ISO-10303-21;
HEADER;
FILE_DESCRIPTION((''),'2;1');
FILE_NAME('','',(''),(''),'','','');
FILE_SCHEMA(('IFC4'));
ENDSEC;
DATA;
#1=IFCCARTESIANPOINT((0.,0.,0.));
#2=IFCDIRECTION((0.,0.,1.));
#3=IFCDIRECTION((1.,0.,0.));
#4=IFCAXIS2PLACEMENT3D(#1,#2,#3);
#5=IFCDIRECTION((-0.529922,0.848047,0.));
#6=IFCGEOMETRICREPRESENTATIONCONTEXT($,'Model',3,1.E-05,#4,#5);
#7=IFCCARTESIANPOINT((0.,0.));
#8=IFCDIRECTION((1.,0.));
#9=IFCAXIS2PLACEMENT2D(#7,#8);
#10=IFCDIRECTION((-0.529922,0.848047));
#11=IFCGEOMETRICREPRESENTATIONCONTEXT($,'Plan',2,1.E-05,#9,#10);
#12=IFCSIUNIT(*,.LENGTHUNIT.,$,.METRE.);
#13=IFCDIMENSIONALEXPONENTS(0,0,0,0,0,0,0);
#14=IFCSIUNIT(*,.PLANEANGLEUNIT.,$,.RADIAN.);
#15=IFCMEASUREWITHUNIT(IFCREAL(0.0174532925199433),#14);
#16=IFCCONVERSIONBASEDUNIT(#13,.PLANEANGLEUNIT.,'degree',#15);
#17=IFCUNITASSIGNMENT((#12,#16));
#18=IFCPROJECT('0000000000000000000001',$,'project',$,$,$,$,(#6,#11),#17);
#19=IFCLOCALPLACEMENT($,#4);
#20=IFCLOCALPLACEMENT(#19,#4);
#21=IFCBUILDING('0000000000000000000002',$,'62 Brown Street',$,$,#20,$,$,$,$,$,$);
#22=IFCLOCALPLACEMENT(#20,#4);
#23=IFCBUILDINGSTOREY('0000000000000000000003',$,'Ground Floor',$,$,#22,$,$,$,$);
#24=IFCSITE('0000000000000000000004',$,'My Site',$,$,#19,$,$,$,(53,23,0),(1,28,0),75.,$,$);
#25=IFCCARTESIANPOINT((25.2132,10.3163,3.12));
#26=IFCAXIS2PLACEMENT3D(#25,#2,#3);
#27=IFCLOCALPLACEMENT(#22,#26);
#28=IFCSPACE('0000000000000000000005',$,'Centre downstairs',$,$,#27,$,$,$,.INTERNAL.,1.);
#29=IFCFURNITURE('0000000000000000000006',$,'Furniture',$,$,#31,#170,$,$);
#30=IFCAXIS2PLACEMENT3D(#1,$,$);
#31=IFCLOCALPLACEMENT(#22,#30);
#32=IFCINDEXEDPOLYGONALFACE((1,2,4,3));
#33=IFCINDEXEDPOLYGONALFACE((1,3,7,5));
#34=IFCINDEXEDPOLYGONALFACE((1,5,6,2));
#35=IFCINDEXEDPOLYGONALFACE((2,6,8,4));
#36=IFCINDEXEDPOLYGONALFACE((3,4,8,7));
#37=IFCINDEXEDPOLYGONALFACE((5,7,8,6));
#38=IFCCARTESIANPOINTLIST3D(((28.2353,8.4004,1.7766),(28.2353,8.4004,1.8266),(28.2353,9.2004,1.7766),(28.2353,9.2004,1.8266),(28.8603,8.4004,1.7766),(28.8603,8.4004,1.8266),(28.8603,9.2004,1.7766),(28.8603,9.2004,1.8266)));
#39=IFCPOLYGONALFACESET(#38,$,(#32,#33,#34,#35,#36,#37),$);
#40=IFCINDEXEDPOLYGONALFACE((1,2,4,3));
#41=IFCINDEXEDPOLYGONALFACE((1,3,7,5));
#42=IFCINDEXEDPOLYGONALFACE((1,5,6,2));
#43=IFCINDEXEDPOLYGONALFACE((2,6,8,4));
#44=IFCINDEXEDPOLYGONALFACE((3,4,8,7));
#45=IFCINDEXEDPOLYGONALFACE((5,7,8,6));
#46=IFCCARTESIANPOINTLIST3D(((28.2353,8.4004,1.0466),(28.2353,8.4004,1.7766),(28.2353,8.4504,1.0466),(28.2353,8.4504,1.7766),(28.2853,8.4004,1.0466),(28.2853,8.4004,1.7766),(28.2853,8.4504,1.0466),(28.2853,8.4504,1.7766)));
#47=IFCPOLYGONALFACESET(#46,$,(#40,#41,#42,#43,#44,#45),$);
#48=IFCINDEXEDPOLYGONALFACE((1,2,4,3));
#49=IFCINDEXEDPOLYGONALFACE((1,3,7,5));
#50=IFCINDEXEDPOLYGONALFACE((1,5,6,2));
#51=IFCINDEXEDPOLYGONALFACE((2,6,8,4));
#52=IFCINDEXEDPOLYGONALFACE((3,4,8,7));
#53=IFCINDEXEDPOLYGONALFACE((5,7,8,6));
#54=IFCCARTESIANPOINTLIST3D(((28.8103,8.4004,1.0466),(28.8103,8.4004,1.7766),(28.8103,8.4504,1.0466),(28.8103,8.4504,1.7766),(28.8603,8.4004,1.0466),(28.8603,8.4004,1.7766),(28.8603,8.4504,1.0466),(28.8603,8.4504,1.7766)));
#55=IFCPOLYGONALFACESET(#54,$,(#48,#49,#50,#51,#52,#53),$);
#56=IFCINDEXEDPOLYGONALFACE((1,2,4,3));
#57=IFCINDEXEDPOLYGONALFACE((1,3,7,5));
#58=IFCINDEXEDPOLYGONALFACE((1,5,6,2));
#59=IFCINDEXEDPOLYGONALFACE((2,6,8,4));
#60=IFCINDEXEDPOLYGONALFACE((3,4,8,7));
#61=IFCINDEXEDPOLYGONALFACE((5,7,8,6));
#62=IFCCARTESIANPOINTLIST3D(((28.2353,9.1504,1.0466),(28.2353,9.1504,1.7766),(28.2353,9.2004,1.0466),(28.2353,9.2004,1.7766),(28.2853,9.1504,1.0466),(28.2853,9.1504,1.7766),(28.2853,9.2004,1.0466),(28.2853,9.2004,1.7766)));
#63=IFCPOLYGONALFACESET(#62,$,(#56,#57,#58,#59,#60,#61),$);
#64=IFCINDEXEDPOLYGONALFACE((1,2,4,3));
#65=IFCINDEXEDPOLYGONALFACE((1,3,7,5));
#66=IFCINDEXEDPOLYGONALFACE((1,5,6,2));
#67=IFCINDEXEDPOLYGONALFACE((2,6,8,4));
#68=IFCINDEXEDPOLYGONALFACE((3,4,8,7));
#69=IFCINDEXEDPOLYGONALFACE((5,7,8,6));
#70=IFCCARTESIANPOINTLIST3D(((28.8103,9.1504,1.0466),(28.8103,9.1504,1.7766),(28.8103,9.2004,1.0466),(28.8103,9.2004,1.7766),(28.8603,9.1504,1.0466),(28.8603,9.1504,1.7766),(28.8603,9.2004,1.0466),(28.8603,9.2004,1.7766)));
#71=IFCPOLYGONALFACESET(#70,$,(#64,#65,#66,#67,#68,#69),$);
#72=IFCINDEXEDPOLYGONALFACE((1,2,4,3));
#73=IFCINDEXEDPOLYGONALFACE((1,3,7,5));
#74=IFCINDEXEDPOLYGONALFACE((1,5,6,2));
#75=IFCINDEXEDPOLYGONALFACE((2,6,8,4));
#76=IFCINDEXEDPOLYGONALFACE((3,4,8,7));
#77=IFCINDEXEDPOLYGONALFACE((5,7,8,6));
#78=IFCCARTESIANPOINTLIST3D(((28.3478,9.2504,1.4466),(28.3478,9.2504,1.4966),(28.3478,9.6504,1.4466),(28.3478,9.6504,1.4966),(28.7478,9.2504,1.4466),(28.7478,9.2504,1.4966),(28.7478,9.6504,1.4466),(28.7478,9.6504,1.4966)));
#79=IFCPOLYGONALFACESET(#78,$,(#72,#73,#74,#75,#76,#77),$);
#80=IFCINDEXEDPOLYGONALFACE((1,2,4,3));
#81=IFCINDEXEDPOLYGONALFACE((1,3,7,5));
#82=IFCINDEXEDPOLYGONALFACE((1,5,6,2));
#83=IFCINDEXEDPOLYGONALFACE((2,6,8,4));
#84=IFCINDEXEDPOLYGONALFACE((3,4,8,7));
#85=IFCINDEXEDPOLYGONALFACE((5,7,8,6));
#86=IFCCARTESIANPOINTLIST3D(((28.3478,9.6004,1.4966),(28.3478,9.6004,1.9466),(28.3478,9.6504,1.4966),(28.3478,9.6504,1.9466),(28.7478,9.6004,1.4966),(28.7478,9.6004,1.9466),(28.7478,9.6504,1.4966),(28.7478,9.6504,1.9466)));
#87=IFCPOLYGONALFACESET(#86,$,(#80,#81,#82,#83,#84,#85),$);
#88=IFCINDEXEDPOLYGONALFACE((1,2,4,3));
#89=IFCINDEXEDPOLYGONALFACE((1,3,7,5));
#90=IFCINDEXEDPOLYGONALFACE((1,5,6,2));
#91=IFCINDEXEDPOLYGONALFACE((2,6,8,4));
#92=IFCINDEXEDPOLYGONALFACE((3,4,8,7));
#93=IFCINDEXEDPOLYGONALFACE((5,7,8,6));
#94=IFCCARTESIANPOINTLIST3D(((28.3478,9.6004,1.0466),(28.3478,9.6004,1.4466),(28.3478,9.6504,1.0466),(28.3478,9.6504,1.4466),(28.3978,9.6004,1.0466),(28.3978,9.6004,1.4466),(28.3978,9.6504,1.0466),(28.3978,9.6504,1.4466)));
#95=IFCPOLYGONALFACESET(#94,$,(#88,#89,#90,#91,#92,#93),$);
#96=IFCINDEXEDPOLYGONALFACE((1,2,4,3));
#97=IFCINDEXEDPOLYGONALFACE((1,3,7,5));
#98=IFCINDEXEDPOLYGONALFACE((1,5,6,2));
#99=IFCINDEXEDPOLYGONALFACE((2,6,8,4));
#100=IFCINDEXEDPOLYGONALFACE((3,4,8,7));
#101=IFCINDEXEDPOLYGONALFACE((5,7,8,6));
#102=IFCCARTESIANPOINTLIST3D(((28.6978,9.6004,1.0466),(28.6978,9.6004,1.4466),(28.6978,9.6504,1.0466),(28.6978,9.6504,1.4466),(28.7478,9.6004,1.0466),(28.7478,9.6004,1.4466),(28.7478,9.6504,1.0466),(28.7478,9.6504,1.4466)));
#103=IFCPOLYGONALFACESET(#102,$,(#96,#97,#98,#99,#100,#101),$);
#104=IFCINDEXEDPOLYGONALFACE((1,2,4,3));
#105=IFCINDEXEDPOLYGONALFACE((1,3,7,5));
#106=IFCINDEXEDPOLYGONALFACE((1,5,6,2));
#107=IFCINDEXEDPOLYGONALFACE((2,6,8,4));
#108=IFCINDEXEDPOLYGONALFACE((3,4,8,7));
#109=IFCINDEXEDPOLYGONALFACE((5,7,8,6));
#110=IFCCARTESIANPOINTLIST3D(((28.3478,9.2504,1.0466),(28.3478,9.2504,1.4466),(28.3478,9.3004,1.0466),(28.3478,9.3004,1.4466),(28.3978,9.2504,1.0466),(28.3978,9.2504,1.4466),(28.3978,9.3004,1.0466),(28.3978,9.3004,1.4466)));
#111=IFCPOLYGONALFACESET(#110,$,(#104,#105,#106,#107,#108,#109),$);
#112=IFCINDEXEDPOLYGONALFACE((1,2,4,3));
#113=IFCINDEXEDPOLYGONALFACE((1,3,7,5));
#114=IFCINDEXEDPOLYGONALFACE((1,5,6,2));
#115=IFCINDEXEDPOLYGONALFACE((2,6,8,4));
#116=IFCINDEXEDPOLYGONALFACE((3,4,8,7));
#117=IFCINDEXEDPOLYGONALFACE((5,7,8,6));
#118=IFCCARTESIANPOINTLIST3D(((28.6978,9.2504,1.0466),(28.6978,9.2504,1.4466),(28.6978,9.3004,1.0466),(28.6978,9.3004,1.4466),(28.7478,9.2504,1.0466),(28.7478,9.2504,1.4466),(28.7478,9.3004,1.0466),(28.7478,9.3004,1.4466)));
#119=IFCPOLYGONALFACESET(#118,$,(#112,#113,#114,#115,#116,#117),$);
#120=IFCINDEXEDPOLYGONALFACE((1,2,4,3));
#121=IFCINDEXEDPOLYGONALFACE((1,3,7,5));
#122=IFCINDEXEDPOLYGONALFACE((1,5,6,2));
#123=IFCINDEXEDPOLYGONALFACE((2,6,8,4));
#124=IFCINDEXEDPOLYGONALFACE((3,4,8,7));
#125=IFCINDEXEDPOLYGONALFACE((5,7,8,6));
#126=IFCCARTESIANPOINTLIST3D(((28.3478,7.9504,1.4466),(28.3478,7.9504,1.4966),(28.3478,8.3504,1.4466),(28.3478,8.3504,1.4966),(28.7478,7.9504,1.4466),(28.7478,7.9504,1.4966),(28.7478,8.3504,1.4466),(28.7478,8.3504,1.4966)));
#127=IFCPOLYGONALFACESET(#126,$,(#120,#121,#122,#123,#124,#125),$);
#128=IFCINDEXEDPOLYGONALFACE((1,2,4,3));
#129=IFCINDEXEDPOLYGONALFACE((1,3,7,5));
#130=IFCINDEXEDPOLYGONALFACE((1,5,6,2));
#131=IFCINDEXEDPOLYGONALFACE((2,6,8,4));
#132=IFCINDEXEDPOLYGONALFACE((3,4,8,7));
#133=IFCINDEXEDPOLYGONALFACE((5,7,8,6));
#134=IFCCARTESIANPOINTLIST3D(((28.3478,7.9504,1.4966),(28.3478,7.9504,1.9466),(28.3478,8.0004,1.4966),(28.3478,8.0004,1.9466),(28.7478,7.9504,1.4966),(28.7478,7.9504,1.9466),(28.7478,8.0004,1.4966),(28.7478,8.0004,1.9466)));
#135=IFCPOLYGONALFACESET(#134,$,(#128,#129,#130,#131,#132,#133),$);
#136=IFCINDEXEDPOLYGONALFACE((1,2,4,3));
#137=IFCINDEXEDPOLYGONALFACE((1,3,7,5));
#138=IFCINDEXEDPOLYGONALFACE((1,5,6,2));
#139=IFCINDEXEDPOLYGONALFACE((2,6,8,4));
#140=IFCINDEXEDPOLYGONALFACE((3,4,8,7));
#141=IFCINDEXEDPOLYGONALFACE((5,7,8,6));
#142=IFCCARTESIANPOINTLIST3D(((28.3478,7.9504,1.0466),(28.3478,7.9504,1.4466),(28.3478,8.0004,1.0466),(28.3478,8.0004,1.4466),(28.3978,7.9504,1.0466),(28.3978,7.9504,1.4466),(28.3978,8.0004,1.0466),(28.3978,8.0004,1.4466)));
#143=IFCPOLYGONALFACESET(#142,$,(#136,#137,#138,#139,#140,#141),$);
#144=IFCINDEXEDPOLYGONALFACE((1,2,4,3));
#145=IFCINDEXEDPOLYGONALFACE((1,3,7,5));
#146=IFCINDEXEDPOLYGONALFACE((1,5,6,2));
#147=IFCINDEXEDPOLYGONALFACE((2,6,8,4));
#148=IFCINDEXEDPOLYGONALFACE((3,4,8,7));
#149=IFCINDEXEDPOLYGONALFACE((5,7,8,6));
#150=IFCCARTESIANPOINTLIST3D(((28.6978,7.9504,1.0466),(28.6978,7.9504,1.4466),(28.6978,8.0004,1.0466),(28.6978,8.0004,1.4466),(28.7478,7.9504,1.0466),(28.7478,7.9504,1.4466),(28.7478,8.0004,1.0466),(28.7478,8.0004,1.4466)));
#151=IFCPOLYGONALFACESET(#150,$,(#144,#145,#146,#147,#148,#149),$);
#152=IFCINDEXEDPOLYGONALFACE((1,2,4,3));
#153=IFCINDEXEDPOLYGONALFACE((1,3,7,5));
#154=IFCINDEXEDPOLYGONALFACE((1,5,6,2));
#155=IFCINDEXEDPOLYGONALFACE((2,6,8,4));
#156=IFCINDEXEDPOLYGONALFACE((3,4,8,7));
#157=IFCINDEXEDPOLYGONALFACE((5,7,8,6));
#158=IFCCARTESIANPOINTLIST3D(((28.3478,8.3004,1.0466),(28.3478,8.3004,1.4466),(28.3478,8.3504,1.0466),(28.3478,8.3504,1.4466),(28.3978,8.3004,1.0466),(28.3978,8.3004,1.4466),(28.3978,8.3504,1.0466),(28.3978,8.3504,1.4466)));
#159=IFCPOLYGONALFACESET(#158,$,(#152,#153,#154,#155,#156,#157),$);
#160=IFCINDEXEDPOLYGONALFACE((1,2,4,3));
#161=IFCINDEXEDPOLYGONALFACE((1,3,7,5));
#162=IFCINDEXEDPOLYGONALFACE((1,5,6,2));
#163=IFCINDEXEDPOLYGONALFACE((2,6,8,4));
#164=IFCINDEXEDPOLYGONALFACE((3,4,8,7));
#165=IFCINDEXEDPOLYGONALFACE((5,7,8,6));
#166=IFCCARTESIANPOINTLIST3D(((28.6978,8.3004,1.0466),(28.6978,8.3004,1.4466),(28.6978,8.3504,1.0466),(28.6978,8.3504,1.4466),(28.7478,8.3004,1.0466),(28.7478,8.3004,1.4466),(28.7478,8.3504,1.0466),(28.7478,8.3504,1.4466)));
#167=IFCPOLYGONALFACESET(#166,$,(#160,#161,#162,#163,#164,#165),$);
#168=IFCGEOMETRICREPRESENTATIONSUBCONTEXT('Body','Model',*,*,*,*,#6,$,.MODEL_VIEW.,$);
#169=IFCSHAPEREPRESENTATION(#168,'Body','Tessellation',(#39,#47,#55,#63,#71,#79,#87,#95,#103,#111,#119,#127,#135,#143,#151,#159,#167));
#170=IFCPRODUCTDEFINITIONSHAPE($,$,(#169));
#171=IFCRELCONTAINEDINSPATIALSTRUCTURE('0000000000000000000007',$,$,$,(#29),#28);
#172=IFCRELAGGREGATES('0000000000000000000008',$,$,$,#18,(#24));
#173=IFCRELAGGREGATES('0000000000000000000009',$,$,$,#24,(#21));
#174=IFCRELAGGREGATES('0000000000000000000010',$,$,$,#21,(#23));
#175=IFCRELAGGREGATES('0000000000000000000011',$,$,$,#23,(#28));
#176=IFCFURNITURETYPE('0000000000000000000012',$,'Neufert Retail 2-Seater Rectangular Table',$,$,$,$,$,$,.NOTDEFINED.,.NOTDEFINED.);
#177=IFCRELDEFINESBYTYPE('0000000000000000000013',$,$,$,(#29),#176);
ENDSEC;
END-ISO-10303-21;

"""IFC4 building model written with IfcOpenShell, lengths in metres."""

from ifc_helpers import new_model, entity, si_unit, converted_unit, direction, frame, origin_with_axes, origin_2d_with_axis, place, context, subcontext, project, spatial, line, indexed_curve, outline, extrude, shape, source, transform, mapped, type_object, type_shapes, element, save


model = new_model("IFC4")

# Units and contexts
model_context = context("Model", 3, precision=1e-05, world=origin_with_axes(), true_north=direction((-0.529922, 0.848047, 0.0)))
plan_context = context("Plan", 2, precision=1e-05, world=origin_2d_with_axis(), true_north=direction((-0.529922, 0.848047)))
body_context_1 = subcontext(model_context, "Body", "Model", "MODEL_VIEW")
body_context_2 = subcontext(plan_context, "Body", "Plan", "PLAN_VIEW")
ifc_project = project(units=[si_unit("LENGTHUNIT", "METRE"), converted_unit("PLANEANGLEUNIT", "degree", entity("IfcReal", 0.0174532925199433), si_unit("PLANEANGLEUNIT", "RADIAN"), dimensions=[0, 0, 0, 0, 0, 0, 0])], contexts=[model_context, plan_context])

# Site, building, storey
site_placement = place(None, origin_with_axes())
site = spatial("IfcSite", under=ifc_project, at=site_placement, Name="My Site", RefLatitude=(53, 23, 0), RefLongitude=(1, 28, 0), RefElevation=75.0)
building_placement = place(site_placement, origin_with_axes())
building = spatial("IfcBuilding", under=site, at=building_placement, Name="62 Brown Street")
storey_placement = place(building_placement, origin_with_axes())
storey = spatial("IfcBuildingStorey", under=building, at=storey_placement, Name="Ground Floor")

# Shared definitions
space_placement = place(storey_placement, frame((25.2132, 10.3163, 3.12), z_axis=(0.0, 0.0, 1.0), x_axis=(1.0, 0.0, 0.0)))
space = spatial("IfcSpace", under=storey, at=space_placement, Name="Centre downstairs", PredefinedType="INTERNAL", ElevationWithFlooring=1.0)

# Furniture
furniture_type_1 = type_object("IfcFurnitureType", Name="Neufert Retail 2-Seater Rectangular Table", AssemblyPlace="NOTDEFINED", PredefinedType="NOTDEFINED")
shared_shape_1 = source(origin_with_axes(), body_context_1, "Body", "SweptSolid", [
    extrude(outline(indexed_curve([(0.0, 0.0), (0.625, 0.0), (0.625, 0.8), (0.0, 0.8)], segments=[line(1, 2, 3, 4, 1)])), frame((-0.3125, -0.4, 0.73), z_axis=(0.0, 0.0, 1.0), x_axis=(1.0, 0.0, 0.0)), (0.0, 0.0, 1.0), 0.05),
    extrude(outline(indexed_curve([(0.0, 0.0), (0.05, 0.0), (0.05, 0.05), (0.0, 0.05)], segments=[line(1, 2, 3, 4, 1)])), frame((-0.3125, -0.4, 0.0), z_axis=(0.0, 0.0, 1.0), x_axis=(1.0, 0.0, 0.0)), (0.0, 0.0, 1.0), 0.73),
    extrude(outline(indexed_curve([(0.625, 0.0), (0.575, 0.0), (0.575, 0.05), (0.625, 0.05)], segments=[line(1, 2, 3, 4, 1)])), frame((-0.3125, -0.4, 0.0), z_axis=(0.0, 0.0, 1.0), x_axis=(1.0, 0.0, 0.0)), (0.0, 0.0, 1.0), 0.73),
    extrude(outline(indexed_curve([(0.0, 0.8), (0.05, 0.8), (0.05, 0.75), (0.0, 0.75)], segments=[line(1, 2, 3, 4, 1)])), frame((-0.3125, -0.4, 0.0), z_axis=(0.0, 0.0, 1.0), x_axis=(1.0, 0.0, 0.0)), (0.0, 0.0, 1.0), 0.73),
    extrude(outline(indexed_curve([(0.625, 0.8), (0.575, 0.8), (0.575, 0.75), (0.625, 0.75)], segments=[line(1, 2, 3, 4, 1)])), frame((-0.3125, -0.4, 0.0), z_axis=(0.0, 0.0, 1.0), x_axis=(1.0, 0.0, 0.0)), (0.0, 0.0, 1.0), 0.73),
    extrude(outline(indexed_curve([(-0.2, 0.0), (0.2, 0.0), (0.2, -0.4), (-0.2, -0.4)], segments=[line(1, 2, 3, 4, 1)])), frame((0.0, 0.85, 0.45), z_axis=(0.0, 0.0, 1.0), x_axis=(1.0, 0.0, 0.0)), (0.0, 0.0, -1.0), 0.05),
    extrude(outline(indexed_curve([(-0.2, 0.0), (0.2, 0.0), (0.2, -0.05), (-0.2, -0.05)], segments=[line(1, 2, 3, 4, 1)])), frame((0.0, 0.85, 0.9), z_axis=(0.0, 0.0, 1.0), x_axis=(1.0, 0.0, 0.0)), (0.0, 0.0, -1.0), 0.45),
    extrude(outline(indexed_curve([(-0.2, 0.0), (-0.15, 0.0), (-0.15, -0.05), (-0.2, -0.05)], segments=[line(1, 2, 3, 4, 1)])), frame((0.0, 0.85, 0.0), z_axis=(0.0, 0.0, 1.0), x_axis=(1.0, 0.0, 0.0)), (0.0, 0.0, 1.0), 0.4),
    extrude(outline(indexed_curve([(0.2, 0.0), (0.15, 0.0), (0.15, -0.05), (0.2, -0.05)], segments=[line(1, 2, 3, 4, 1)])), frame((0.0, 0.85, 0.0), z_axis=(0.0, 0.0, 1.0), x_axis=(1.0, 0.0, 0.0)), (0.0, 0.0, 1.0), 0.4),
    extrude(outline(indexed_curve([(-0.2, -0.4), (-0.15, -0.4), (-0.15, -0.35), (-0.2, -0.35)], segments=[line(1, 2, 3, 4, 1)])), frame((0.0, 0.85, 0.0), z_axis=(0.0, 0.0, 1.0), x_axis=(1.0, 0.0, 0.0)), (0.0, 0.0, 1.0), 0.4),
    extrude(outline(indexed_curve([(0.2, -0.4), (0.15, -0.4), (0.15, -0.35), (0.2, -0.35)], segments=[line(1, 2, 3, 4, 1)])), frame((0.0, 0.85, 0.0), z_axis=(0.0, 0.0, 1.0), x_axis=(1.0, 0.0, 0.0)), (0.0, 0.0, 1.0), 0.4),
    extrude(outline(indexed_curve([(-0.2, 0.0), (0.2, 0.0), (0.2, 0.4), (-0.2, 0.4)], segments=[line(1, 2, 3, 4, 1)])), frame((0.0, -0.85, 0.45), z_axis=(0.0, 0.0, 1.0), x_axis=(1.0, 0.0, 0.0)), (0.0, 0.0, -1.0), 0.05),
    extrude(outline(indexed_curve([(-0.2, 0.0), (0.2, 0.0), (0.2, 0.05), (-0.2, 0.05)], segments=[line(1, 2, 3, 4, 1)])), frame((0.0, -0.85, 0.9), z_axis=(0.0, 0.0, 1.0), x_axis=(1.0, 0.0, 0.0)), (0.0, 0.0, -1.0), 0.45),
    extrude(outline(indexed_curve([(-0.2, 0.0), (-0.15, 0.0), (-0.15, 0.05), (-0.2, 0.05)], segments=[line(1, 2, 3, 4, 1)])), frame((0.0, -0.85, 0.0), z_axis=(0.0, 0.0, 1.0), x_axis=(1.0, 0.0, 0.0)), (0.0, 0.0, 1.0), 0.4),
    extrude(outline(indexed_curve([(0.2, 0.0), (0.15, 0.0), (0.15, 0.05), (0.2, 0.05)], segments=[line(1, 2, 3, 4, 1)])), frame((0.0, -0.85, 0.0), z_axis=(0.0, 0.0, 1.0), x_axis=(1.0, 0.0, 0.0)), (0.0, 0.0, 1.0), 0.4),
    extrude(outline(indexed_curve([(-0.2, 0.4), (-0.15, 0.4), (-0.15, 0.35), (-0.2, 0.35)], segments=[line(1, 2, 3, 4, 1)])), frame((0.0, -0.85, 0.0), z_axis=(0.0, 0.0, 1.0), x_axis=(1.0, 0.0, 0.0)), (0.0, 0.0, 1.0), 0.4),
    extrude(outline(indexed_curve([(0.2, 0.4), (0.15, 0.4), (0.15, 0.35), (0.2, 0.35)], segments=[line(1, 2, 3, 4, 1)])), frame((0.0, -0.85, 0.0), z_axis=(0.0, 0.0, 1.0), x_axis=(1.0, 0.0, 0.0)), (0.0, 0.0, 1.0), 0.4),
])
shared_shape_2 = source(origin_with_axes(), body_context_2, "Body", "Curve2D", [
    entity("IfcIndexedPolyCurve", entity("IfcCartesianPointList2D", [[-0.3125, -0.4], [0.3125, -0.4], [0.3125, 0.4], [-0.3125, 0.4]]), [entity("IfcLineIndex", [1, 2, 3, 4, 1])]),
    entity("IfcIndexedPolyCurve", entity("IfcCartesianPointList2D", [[-0.2, 0.45], [0.2, 0.45]])),
    entity("IfcIndexedPolyCurve", entity("IfcCartesianPointList2D", [[-0.2, 0.45], [-0.2, 0.65], [-0.1414, 0.7914], [0.0, 0.85], [0.1414, 0.7914], [0.2, 0.65], [0.2, 0.45]]), [entity("IfcLineIndex", [1, 2]), entity("IfcArcIndex", [2, 3, 4]), entity("IfcArcIndex", [4, 5, 6]), entity("IfcLineIndex", [6, 7])]),
    entity("IfcIndexedPolyCurve", entity("IfcCartesianPointList2D", [[-0.16, 0.45], [-0.16, 0.65], [-0.1131, 0.7631], [0.0, 0.81], [0.1131, 0.7631], [0.16, 0.65], [0.16, 0.45]]), [entity("IfcLineIndex", [1, 2]), entity("IfcArcIndex", [2, 3, 4]), entity("IfcArcIndex", [4, 5, 6]), entity("IfcLineIndex", [6, 7])]),
    entity("IfcIndexedPolyCurve", entity("IfcCartesianPointList2D", [[-0.2, -0.45], [0.2, -0.45]])),
    entity("IfcIndexedPolyCurve", entity("IfcCartesianPointList2D", [[-0.2, -0.45], [-0.2, -0.65], [-0.1414, -0.7914], [0.0, -0.85], [0.1414, -0.7914], [0.2, -0.65], [0.2, -0.45]]), [entity("IfcLineIndex", [1, 2]), entity("IfcArcIndex", [2, 3, 4]), entity("IfcArcIndex", [4, 5, 6]), entity("IfcLineIndex", [6, 7])]),
    entity("IfcIndexedPolyCurve", entity("IfcCartesianPointList2D", [[-0.16, -0.45], [-0.16, -0.65], [-0.1131, -0.7631], [0.0, -0.81], [0.1131, -0.7631], [0.16, -0.65], [0.16, -0.45]]), [entity("IfcLineIndex", [1, 2]), entity("IfcArcIndex", [2, 3, 4]), entity("IfcArcIndex", [4, 5, 6]), entity("IfcLineIndex", [6, 7])]),
])
type_shapes(furniture_type_1, [shared_shape_1, shared_shape_2])
furniture_placement = place(space_placement, frame((3.3346, -1.5159, -2.0734), z_axis=(0.0, 0.0, 1.0), x_axis=(1.0, 0.0, 0.0)))
element("IfcFurniture", 1, at=furniture_placement, inside=space, type_object=furniture_type_1, Name="Furniture", shapes=[
    shape(body_context_1, "Body", "MappedRepresentation", [mapped(shared_shape_1, transform((0.0, 0.0, 0.0), x_axis=(1.0, 0.0, 0.0), y_axis=(0.0, 1.0, 0.0), z_axis=(0.0, 0.0, 1.0), scale=1.0))]),
    shape(body_context_2, "Body", "MappedRepresentation", [mapped(shared_shape_2, transform((0.0, 0.0, 0.0), x_axis=(1.0, 0.0, 0.0), y_axis=(0.0, 1.0, 0.0), z_axis=(0.0, 0.0, 1.0), scale=1.0))]),
])

save(model, "model.ifc")
